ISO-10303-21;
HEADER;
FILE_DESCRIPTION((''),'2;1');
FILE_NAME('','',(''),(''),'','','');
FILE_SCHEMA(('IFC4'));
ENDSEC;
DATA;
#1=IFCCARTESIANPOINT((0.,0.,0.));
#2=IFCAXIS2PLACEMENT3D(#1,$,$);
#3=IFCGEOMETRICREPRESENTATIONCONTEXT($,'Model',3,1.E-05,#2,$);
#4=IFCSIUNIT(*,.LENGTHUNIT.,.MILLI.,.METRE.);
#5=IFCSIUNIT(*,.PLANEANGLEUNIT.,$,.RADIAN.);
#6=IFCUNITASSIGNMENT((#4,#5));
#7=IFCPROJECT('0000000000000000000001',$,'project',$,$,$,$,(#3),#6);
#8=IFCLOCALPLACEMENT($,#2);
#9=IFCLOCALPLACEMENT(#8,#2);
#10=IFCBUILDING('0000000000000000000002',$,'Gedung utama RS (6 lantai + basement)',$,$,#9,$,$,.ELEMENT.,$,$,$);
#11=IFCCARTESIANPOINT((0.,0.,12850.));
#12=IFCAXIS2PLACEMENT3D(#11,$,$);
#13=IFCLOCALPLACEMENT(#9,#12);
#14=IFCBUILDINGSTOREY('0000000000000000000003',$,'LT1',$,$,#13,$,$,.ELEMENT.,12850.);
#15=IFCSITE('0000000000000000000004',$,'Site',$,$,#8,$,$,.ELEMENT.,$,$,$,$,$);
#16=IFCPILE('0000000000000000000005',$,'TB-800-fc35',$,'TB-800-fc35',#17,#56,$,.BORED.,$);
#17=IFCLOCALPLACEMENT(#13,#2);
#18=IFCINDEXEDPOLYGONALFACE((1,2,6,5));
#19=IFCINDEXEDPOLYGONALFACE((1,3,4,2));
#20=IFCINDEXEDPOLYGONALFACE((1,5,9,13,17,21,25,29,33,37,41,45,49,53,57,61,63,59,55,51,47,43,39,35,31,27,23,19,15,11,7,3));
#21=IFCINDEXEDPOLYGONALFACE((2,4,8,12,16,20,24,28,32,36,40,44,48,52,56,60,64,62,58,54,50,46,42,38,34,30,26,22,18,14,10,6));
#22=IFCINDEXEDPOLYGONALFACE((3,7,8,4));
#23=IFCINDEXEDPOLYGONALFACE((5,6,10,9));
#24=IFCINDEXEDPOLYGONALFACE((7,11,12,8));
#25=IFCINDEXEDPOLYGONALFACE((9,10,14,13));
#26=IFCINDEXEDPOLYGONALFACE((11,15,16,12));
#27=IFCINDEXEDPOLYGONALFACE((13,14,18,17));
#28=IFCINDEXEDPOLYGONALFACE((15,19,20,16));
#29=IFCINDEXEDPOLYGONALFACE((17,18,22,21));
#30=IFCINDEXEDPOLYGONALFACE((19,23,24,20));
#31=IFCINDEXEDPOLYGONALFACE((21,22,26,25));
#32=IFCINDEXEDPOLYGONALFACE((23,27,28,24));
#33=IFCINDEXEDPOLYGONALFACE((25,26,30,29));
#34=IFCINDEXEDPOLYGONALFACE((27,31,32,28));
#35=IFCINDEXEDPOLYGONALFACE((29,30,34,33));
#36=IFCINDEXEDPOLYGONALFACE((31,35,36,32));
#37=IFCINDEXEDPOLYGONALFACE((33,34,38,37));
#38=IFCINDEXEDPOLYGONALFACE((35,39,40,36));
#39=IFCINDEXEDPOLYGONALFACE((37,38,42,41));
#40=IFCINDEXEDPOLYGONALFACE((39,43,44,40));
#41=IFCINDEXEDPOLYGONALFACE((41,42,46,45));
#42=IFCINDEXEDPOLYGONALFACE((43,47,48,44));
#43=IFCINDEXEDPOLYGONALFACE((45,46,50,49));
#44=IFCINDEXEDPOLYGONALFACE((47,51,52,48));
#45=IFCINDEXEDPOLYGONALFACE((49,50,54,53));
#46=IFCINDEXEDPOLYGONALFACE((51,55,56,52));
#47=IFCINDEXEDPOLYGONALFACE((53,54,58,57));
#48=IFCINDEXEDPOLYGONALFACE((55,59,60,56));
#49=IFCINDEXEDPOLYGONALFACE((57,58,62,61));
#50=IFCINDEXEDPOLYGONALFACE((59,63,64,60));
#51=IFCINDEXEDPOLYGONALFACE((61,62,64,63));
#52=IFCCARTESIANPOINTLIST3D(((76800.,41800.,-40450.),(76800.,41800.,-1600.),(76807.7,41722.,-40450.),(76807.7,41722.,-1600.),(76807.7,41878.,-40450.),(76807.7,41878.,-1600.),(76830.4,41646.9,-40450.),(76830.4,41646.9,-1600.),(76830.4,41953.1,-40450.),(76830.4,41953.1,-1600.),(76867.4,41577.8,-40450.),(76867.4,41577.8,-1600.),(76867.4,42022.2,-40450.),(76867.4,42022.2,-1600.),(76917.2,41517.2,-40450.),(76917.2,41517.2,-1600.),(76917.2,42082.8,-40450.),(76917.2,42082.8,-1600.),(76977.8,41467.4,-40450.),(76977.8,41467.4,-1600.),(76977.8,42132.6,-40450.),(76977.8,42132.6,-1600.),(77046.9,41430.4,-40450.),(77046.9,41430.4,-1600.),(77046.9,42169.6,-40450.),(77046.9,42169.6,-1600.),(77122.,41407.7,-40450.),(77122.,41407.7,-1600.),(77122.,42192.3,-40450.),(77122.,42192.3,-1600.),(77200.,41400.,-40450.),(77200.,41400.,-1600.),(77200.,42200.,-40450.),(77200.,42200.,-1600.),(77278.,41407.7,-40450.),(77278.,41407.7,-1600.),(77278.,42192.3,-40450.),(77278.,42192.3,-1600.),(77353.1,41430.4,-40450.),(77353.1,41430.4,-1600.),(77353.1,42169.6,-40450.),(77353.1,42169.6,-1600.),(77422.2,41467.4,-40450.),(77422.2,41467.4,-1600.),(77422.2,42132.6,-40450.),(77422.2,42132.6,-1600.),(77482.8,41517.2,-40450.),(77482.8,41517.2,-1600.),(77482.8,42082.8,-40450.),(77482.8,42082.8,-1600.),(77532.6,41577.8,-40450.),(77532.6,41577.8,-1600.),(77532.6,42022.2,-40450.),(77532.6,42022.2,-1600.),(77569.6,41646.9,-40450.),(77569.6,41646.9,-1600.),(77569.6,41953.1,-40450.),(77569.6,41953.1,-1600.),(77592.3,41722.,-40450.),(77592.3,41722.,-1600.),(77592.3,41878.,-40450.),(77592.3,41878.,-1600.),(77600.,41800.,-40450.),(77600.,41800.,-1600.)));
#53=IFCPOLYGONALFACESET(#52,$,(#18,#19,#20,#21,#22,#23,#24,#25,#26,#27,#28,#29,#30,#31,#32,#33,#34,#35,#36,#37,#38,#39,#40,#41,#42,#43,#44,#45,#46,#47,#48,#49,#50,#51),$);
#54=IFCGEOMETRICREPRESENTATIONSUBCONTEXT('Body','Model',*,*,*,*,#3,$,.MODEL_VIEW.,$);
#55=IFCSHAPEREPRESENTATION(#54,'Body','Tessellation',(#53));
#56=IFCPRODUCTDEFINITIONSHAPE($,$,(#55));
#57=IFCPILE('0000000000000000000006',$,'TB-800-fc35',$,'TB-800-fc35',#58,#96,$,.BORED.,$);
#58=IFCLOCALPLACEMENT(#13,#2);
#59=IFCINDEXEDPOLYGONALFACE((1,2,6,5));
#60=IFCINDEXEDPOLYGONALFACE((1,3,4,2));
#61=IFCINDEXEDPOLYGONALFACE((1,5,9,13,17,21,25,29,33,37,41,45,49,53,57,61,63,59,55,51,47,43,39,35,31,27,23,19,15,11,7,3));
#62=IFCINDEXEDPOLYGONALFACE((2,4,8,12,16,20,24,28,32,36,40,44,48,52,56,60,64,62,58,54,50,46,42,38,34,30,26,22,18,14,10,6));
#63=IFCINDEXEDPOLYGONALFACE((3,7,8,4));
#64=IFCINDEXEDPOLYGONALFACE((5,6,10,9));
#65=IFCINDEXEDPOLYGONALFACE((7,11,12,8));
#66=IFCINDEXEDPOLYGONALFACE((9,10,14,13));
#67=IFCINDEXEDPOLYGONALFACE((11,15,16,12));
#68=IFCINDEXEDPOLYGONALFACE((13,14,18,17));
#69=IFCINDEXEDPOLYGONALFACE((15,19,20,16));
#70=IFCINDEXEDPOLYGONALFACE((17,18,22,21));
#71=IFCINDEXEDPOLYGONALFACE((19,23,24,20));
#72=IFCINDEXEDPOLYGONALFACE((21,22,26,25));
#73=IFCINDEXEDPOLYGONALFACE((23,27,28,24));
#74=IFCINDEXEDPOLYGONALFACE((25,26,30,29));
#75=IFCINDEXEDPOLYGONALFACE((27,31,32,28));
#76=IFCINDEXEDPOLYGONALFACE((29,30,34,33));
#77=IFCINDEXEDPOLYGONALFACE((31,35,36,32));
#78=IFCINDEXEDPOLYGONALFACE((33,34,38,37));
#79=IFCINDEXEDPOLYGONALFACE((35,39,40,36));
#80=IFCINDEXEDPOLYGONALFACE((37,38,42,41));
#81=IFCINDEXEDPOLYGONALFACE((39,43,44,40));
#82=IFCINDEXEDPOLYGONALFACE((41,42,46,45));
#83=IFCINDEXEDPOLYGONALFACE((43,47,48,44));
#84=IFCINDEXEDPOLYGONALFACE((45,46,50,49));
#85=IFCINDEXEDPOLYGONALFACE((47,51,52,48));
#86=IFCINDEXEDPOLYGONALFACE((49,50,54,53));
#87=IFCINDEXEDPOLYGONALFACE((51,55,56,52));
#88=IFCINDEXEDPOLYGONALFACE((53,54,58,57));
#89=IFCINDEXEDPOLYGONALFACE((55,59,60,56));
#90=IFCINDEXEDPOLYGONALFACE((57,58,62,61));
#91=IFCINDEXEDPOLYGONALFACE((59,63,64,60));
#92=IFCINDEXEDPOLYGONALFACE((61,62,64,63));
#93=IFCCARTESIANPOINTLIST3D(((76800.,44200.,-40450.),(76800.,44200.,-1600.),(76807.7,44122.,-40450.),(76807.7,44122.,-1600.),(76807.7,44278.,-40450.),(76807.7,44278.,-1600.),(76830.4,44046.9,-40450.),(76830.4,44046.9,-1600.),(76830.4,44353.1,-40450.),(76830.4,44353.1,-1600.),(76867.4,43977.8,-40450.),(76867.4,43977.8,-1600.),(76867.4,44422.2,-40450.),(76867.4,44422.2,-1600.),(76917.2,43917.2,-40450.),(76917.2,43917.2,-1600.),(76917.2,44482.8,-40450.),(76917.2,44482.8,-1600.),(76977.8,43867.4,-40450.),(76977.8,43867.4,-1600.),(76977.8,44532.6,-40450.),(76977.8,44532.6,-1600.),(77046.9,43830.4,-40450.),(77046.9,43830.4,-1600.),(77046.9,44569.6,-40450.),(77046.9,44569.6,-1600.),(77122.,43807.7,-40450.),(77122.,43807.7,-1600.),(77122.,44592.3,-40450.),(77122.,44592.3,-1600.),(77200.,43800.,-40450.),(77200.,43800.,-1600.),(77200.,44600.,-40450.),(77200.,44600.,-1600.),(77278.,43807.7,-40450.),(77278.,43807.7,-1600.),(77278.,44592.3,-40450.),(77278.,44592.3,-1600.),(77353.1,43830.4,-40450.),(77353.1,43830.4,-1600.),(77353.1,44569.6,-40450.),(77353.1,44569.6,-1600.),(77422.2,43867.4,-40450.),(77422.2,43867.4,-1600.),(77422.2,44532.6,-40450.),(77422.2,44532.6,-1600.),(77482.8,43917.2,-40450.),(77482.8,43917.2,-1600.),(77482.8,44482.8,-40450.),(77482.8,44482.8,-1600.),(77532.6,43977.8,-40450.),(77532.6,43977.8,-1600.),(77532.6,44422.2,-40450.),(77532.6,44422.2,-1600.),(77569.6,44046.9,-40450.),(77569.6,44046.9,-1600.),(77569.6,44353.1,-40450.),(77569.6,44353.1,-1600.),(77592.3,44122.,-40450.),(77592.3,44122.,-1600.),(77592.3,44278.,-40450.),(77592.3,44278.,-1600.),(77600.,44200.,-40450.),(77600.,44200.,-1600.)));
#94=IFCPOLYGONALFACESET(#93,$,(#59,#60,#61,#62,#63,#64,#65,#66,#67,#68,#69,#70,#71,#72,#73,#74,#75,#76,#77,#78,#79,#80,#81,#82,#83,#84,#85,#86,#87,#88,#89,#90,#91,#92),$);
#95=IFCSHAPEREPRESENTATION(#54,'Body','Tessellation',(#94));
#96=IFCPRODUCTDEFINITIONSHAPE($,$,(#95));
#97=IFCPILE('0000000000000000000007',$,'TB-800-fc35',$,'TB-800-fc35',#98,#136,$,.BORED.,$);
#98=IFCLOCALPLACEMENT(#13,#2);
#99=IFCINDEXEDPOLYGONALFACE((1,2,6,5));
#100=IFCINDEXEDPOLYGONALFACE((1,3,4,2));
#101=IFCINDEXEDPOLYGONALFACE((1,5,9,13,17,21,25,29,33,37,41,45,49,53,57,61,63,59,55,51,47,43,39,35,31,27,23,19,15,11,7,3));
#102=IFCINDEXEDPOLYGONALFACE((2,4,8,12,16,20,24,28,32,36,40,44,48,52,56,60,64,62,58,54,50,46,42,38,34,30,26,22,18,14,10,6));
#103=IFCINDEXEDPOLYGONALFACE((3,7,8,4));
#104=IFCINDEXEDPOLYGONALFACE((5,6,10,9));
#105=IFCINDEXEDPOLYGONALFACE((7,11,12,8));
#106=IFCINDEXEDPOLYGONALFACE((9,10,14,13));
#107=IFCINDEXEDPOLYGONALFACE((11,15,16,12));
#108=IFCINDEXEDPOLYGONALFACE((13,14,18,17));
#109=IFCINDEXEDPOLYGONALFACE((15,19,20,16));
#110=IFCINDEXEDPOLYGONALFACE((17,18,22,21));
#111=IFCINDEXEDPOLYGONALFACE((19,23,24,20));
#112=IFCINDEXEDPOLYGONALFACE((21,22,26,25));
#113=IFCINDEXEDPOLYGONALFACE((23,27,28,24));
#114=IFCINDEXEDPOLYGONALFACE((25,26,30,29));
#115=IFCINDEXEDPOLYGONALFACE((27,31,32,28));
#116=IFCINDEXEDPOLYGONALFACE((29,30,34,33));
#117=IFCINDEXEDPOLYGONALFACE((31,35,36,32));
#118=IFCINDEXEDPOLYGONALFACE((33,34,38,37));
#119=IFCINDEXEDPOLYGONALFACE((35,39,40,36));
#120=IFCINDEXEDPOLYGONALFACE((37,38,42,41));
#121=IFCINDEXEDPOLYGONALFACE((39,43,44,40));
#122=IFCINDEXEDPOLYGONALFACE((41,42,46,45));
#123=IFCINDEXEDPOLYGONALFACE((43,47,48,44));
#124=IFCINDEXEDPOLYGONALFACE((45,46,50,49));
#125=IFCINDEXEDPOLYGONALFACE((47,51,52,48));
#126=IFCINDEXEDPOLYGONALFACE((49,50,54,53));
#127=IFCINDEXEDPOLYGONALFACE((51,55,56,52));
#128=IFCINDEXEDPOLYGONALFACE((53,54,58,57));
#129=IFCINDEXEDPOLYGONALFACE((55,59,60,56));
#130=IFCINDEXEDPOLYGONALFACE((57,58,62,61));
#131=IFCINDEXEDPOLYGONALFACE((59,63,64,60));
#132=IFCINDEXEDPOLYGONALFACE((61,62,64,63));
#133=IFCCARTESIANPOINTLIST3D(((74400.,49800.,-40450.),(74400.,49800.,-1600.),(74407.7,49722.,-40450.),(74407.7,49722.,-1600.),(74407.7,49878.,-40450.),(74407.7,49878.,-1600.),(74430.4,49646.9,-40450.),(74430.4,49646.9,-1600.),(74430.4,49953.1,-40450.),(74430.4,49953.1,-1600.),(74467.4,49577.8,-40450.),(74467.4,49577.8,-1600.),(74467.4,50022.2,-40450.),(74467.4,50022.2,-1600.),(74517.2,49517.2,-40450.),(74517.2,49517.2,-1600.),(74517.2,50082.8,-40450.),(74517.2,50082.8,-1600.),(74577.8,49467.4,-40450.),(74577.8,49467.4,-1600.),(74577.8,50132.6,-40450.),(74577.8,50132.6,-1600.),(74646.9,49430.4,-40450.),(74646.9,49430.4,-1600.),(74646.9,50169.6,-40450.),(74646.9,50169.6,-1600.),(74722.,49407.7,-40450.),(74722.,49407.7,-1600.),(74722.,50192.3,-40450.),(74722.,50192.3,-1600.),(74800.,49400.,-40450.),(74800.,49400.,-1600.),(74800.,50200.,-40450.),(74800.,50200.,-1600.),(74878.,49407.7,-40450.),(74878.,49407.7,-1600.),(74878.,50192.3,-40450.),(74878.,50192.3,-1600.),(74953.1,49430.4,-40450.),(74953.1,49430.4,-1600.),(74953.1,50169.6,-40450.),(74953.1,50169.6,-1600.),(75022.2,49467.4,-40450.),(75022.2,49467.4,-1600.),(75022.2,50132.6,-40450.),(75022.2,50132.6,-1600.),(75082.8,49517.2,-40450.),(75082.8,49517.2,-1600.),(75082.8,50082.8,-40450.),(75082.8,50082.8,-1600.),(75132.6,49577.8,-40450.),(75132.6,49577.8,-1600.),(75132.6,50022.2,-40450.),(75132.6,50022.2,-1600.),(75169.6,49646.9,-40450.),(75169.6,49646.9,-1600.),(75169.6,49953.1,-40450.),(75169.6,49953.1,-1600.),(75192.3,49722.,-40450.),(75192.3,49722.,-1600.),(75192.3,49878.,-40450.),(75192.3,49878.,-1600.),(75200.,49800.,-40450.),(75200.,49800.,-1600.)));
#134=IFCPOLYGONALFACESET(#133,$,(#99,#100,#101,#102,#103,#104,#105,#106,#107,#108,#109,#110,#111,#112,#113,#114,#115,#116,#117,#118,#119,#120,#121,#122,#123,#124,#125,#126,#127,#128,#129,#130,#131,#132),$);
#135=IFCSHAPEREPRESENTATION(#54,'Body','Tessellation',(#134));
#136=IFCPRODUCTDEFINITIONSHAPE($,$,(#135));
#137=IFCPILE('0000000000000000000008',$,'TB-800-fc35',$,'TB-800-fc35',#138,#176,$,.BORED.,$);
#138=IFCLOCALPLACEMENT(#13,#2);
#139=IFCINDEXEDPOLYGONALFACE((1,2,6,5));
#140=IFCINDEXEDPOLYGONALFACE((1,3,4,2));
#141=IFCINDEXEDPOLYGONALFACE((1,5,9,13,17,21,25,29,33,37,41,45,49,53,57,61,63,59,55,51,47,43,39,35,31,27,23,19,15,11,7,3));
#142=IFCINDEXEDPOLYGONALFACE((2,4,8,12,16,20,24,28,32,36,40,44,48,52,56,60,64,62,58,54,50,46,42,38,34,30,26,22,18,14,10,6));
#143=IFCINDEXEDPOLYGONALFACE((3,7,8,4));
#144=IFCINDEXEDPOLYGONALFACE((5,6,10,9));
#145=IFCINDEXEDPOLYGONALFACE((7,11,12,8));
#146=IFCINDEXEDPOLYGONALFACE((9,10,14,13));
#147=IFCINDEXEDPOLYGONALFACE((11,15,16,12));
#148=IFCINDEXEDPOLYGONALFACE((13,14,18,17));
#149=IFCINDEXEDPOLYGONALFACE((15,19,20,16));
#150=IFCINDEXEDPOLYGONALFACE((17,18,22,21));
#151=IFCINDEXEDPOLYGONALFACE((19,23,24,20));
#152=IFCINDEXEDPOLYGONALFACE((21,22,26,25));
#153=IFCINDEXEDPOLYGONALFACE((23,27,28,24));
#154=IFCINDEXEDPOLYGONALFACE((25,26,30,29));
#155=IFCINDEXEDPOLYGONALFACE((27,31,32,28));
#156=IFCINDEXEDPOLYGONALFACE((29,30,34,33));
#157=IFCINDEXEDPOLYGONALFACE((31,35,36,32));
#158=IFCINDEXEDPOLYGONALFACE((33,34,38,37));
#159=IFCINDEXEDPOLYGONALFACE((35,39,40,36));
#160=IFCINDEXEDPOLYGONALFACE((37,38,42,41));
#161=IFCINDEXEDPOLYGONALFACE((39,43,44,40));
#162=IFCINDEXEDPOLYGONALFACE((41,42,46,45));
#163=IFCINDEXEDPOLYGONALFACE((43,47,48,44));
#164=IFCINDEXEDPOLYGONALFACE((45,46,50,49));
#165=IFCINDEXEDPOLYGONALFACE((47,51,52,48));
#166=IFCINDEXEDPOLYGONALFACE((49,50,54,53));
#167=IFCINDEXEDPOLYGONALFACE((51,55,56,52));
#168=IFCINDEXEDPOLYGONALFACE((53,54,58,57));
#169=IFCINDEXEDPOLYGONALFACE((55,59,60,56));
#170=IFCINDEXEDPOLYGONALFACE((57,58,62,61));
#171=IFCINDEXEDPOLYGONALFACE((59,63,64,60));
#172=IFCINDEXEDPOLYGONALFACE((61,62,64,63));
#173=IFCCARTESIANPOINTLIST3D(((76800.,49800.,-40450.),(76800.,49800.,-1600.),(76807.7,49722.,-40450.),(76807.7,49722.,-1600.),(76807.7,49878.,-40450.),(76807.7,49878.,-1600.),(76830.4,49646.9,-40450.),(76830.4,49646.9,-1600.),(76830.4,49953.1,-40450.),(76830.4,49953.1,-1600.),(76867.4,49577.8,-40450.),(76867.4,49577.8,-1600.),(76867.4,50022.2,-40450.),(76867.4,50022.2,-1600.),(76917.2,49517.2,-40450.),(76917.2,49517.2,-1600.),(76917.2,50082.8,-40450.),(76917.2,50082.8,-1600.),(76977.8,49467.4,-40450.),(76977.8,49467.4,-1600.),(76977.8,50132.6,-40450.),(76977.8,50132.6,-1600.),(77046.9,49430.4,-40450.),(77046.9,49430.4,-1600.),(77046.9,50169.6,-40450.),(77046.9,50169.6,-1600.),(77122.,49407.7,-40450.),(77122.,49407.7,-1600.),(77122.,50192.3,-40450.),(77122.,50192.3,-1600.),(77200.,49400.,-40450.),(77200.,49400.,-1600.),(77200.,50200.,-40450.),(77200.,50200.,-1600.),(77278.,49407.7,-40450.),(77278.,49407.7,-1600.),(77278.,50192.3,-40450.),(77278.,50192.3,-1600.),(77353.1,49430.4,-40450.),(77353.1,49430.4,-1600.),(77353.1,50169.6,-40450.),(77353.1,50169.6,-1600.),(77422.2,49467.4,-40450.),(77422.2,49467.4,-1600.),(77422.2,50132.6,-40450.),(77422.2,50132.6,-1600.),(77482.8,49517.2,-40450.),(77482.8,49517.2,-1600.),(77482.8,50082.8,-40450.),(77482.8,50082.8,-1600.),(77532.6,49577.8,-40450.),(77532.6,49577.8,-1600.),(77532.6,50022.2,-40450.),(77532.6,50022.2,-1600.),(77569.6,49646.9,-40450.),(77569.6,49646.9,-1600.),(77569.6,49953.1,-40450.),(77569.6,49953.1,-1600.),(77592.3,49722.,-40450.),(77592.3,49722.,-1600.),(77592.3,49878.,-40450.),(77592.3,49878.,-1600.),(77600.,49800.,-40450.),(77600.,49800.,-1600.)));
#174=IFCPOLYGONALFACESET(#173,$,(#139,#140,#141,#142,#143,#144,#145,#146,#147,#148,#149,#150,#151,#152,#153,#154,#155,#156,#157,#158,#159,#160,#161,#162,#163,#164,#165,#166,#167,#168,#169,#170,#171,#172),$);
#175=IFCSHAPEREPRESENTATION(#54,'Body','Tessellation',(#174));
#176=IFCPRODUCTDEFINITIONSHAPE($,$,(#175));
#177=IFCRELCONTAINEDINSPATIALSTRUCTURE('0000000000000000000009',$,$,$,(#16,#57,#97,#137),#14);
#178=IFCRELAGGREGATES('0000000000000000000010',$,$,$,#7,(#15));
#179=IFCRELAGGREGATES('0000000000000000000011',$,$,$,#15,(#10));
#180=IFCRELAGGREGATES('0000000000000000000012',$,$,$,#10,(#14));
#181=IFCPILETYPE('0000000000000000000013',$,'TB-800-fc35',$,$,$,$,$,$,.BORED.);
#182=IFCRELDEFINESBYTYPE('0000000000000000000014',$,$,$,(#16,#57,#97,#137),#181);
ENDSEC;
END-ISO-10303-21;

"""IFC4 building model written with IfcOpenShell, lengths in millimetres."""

from ifc_helpers import new_model, si_unit, frame, origin, origin_2d, place, context, subcontext, project, spatial, circle, extrude, material_profile, profile_set, profile_usage, type_object, element, save


model = new_model("IFC4")

# Units and contexts
model_context = context("Model", 3, precision=1e-05, world=origin())
body_context = subcontext(model_context, "Body", "Model", "MODEL_VIEW")
ifc_project = project(units=[si_unit("LENGTHUNIT", "METRE", prefix="MILLI"), si_unit("PLANEANGLEUNIT", "RADIAN")], contexts=[model_context])

# Site, building, storey
site_placement = place(None, origin())
site = spatial("IfcSite", under=ifc_project, at=site_placement, Name="Site", CompositionType="ELEMENT")
building_placement = place(site_placement, origin())
building = spatial("IfcBuilding", under=site, at=building_placement, Name="Gedung utama RS (6 lantai + basement)", CompositionType="ELEMENT")
storey_placement = place(building_placement, frame((0.0, 0.0, 12850.0)))
storey = spatial("IfcBuildingStorey", under=building, at=storey_placement, Name="LT1", CompositionType="ELEMENT", Elevation=12850.0)

# Piles
ifc_material_profile_1 = material_profile(None, circle(Radius=400.0, at=origin_2d()), Name="TB-800-fc35")
ifc_profile_set_1 = profile_set([ifc_material_profile_1], Name="TB-800-fc35")
ifc_profile_usage_1 = profile_usage(ifc_profile_set_1, cardinal=5)
pile_type = type_object("IfcPileType", Name="TB-800-fc35", PredefinedType="BORED", material=ifc_profile_set_1)
for number, where, z_axis, x_axis, name in (
    (1, (77200.0, 41800.0, -40450.0), (0.0, 0.0, 1.0), (1.0, 0.0, 0.0), "TB-800-fc35"),
    (2, (77200.0, 44200.0, -40450.0), (0.0, 0.0, 1.0), (1.0, 0.0, 0.0), "TB-800-fc35"),
    (3, (74800.0, 49800.0, -40450.0), (0.0, 0.0, 1.0), (1.0, 0.0, 0.0), "TB-800-fc35"),
    (4, (77200.0, 49800.0, -40450.0), (0.0, 0.0, 1.0), (1.0, 0.0, 0.0), "TB-800-fc35"),
):
    element("IfcPile", number, at=place(storey_placement, frame(where, z_axis=z_axis, x_axis=x_axis)), inside=storey, type_object=pile_type, material=ifc_profile_usage_1, Name=name, ObjectType="TB-800-fc35", PredefinedType="BORED", context=body_context, shape_type="SweptSolid", body=[
        extrude(circle(Radius=400.0, at=origin_2d()), origin(), (0.0, 0.0, 1.0), 38850.0),
    ])

save(model, "model.ifc")
